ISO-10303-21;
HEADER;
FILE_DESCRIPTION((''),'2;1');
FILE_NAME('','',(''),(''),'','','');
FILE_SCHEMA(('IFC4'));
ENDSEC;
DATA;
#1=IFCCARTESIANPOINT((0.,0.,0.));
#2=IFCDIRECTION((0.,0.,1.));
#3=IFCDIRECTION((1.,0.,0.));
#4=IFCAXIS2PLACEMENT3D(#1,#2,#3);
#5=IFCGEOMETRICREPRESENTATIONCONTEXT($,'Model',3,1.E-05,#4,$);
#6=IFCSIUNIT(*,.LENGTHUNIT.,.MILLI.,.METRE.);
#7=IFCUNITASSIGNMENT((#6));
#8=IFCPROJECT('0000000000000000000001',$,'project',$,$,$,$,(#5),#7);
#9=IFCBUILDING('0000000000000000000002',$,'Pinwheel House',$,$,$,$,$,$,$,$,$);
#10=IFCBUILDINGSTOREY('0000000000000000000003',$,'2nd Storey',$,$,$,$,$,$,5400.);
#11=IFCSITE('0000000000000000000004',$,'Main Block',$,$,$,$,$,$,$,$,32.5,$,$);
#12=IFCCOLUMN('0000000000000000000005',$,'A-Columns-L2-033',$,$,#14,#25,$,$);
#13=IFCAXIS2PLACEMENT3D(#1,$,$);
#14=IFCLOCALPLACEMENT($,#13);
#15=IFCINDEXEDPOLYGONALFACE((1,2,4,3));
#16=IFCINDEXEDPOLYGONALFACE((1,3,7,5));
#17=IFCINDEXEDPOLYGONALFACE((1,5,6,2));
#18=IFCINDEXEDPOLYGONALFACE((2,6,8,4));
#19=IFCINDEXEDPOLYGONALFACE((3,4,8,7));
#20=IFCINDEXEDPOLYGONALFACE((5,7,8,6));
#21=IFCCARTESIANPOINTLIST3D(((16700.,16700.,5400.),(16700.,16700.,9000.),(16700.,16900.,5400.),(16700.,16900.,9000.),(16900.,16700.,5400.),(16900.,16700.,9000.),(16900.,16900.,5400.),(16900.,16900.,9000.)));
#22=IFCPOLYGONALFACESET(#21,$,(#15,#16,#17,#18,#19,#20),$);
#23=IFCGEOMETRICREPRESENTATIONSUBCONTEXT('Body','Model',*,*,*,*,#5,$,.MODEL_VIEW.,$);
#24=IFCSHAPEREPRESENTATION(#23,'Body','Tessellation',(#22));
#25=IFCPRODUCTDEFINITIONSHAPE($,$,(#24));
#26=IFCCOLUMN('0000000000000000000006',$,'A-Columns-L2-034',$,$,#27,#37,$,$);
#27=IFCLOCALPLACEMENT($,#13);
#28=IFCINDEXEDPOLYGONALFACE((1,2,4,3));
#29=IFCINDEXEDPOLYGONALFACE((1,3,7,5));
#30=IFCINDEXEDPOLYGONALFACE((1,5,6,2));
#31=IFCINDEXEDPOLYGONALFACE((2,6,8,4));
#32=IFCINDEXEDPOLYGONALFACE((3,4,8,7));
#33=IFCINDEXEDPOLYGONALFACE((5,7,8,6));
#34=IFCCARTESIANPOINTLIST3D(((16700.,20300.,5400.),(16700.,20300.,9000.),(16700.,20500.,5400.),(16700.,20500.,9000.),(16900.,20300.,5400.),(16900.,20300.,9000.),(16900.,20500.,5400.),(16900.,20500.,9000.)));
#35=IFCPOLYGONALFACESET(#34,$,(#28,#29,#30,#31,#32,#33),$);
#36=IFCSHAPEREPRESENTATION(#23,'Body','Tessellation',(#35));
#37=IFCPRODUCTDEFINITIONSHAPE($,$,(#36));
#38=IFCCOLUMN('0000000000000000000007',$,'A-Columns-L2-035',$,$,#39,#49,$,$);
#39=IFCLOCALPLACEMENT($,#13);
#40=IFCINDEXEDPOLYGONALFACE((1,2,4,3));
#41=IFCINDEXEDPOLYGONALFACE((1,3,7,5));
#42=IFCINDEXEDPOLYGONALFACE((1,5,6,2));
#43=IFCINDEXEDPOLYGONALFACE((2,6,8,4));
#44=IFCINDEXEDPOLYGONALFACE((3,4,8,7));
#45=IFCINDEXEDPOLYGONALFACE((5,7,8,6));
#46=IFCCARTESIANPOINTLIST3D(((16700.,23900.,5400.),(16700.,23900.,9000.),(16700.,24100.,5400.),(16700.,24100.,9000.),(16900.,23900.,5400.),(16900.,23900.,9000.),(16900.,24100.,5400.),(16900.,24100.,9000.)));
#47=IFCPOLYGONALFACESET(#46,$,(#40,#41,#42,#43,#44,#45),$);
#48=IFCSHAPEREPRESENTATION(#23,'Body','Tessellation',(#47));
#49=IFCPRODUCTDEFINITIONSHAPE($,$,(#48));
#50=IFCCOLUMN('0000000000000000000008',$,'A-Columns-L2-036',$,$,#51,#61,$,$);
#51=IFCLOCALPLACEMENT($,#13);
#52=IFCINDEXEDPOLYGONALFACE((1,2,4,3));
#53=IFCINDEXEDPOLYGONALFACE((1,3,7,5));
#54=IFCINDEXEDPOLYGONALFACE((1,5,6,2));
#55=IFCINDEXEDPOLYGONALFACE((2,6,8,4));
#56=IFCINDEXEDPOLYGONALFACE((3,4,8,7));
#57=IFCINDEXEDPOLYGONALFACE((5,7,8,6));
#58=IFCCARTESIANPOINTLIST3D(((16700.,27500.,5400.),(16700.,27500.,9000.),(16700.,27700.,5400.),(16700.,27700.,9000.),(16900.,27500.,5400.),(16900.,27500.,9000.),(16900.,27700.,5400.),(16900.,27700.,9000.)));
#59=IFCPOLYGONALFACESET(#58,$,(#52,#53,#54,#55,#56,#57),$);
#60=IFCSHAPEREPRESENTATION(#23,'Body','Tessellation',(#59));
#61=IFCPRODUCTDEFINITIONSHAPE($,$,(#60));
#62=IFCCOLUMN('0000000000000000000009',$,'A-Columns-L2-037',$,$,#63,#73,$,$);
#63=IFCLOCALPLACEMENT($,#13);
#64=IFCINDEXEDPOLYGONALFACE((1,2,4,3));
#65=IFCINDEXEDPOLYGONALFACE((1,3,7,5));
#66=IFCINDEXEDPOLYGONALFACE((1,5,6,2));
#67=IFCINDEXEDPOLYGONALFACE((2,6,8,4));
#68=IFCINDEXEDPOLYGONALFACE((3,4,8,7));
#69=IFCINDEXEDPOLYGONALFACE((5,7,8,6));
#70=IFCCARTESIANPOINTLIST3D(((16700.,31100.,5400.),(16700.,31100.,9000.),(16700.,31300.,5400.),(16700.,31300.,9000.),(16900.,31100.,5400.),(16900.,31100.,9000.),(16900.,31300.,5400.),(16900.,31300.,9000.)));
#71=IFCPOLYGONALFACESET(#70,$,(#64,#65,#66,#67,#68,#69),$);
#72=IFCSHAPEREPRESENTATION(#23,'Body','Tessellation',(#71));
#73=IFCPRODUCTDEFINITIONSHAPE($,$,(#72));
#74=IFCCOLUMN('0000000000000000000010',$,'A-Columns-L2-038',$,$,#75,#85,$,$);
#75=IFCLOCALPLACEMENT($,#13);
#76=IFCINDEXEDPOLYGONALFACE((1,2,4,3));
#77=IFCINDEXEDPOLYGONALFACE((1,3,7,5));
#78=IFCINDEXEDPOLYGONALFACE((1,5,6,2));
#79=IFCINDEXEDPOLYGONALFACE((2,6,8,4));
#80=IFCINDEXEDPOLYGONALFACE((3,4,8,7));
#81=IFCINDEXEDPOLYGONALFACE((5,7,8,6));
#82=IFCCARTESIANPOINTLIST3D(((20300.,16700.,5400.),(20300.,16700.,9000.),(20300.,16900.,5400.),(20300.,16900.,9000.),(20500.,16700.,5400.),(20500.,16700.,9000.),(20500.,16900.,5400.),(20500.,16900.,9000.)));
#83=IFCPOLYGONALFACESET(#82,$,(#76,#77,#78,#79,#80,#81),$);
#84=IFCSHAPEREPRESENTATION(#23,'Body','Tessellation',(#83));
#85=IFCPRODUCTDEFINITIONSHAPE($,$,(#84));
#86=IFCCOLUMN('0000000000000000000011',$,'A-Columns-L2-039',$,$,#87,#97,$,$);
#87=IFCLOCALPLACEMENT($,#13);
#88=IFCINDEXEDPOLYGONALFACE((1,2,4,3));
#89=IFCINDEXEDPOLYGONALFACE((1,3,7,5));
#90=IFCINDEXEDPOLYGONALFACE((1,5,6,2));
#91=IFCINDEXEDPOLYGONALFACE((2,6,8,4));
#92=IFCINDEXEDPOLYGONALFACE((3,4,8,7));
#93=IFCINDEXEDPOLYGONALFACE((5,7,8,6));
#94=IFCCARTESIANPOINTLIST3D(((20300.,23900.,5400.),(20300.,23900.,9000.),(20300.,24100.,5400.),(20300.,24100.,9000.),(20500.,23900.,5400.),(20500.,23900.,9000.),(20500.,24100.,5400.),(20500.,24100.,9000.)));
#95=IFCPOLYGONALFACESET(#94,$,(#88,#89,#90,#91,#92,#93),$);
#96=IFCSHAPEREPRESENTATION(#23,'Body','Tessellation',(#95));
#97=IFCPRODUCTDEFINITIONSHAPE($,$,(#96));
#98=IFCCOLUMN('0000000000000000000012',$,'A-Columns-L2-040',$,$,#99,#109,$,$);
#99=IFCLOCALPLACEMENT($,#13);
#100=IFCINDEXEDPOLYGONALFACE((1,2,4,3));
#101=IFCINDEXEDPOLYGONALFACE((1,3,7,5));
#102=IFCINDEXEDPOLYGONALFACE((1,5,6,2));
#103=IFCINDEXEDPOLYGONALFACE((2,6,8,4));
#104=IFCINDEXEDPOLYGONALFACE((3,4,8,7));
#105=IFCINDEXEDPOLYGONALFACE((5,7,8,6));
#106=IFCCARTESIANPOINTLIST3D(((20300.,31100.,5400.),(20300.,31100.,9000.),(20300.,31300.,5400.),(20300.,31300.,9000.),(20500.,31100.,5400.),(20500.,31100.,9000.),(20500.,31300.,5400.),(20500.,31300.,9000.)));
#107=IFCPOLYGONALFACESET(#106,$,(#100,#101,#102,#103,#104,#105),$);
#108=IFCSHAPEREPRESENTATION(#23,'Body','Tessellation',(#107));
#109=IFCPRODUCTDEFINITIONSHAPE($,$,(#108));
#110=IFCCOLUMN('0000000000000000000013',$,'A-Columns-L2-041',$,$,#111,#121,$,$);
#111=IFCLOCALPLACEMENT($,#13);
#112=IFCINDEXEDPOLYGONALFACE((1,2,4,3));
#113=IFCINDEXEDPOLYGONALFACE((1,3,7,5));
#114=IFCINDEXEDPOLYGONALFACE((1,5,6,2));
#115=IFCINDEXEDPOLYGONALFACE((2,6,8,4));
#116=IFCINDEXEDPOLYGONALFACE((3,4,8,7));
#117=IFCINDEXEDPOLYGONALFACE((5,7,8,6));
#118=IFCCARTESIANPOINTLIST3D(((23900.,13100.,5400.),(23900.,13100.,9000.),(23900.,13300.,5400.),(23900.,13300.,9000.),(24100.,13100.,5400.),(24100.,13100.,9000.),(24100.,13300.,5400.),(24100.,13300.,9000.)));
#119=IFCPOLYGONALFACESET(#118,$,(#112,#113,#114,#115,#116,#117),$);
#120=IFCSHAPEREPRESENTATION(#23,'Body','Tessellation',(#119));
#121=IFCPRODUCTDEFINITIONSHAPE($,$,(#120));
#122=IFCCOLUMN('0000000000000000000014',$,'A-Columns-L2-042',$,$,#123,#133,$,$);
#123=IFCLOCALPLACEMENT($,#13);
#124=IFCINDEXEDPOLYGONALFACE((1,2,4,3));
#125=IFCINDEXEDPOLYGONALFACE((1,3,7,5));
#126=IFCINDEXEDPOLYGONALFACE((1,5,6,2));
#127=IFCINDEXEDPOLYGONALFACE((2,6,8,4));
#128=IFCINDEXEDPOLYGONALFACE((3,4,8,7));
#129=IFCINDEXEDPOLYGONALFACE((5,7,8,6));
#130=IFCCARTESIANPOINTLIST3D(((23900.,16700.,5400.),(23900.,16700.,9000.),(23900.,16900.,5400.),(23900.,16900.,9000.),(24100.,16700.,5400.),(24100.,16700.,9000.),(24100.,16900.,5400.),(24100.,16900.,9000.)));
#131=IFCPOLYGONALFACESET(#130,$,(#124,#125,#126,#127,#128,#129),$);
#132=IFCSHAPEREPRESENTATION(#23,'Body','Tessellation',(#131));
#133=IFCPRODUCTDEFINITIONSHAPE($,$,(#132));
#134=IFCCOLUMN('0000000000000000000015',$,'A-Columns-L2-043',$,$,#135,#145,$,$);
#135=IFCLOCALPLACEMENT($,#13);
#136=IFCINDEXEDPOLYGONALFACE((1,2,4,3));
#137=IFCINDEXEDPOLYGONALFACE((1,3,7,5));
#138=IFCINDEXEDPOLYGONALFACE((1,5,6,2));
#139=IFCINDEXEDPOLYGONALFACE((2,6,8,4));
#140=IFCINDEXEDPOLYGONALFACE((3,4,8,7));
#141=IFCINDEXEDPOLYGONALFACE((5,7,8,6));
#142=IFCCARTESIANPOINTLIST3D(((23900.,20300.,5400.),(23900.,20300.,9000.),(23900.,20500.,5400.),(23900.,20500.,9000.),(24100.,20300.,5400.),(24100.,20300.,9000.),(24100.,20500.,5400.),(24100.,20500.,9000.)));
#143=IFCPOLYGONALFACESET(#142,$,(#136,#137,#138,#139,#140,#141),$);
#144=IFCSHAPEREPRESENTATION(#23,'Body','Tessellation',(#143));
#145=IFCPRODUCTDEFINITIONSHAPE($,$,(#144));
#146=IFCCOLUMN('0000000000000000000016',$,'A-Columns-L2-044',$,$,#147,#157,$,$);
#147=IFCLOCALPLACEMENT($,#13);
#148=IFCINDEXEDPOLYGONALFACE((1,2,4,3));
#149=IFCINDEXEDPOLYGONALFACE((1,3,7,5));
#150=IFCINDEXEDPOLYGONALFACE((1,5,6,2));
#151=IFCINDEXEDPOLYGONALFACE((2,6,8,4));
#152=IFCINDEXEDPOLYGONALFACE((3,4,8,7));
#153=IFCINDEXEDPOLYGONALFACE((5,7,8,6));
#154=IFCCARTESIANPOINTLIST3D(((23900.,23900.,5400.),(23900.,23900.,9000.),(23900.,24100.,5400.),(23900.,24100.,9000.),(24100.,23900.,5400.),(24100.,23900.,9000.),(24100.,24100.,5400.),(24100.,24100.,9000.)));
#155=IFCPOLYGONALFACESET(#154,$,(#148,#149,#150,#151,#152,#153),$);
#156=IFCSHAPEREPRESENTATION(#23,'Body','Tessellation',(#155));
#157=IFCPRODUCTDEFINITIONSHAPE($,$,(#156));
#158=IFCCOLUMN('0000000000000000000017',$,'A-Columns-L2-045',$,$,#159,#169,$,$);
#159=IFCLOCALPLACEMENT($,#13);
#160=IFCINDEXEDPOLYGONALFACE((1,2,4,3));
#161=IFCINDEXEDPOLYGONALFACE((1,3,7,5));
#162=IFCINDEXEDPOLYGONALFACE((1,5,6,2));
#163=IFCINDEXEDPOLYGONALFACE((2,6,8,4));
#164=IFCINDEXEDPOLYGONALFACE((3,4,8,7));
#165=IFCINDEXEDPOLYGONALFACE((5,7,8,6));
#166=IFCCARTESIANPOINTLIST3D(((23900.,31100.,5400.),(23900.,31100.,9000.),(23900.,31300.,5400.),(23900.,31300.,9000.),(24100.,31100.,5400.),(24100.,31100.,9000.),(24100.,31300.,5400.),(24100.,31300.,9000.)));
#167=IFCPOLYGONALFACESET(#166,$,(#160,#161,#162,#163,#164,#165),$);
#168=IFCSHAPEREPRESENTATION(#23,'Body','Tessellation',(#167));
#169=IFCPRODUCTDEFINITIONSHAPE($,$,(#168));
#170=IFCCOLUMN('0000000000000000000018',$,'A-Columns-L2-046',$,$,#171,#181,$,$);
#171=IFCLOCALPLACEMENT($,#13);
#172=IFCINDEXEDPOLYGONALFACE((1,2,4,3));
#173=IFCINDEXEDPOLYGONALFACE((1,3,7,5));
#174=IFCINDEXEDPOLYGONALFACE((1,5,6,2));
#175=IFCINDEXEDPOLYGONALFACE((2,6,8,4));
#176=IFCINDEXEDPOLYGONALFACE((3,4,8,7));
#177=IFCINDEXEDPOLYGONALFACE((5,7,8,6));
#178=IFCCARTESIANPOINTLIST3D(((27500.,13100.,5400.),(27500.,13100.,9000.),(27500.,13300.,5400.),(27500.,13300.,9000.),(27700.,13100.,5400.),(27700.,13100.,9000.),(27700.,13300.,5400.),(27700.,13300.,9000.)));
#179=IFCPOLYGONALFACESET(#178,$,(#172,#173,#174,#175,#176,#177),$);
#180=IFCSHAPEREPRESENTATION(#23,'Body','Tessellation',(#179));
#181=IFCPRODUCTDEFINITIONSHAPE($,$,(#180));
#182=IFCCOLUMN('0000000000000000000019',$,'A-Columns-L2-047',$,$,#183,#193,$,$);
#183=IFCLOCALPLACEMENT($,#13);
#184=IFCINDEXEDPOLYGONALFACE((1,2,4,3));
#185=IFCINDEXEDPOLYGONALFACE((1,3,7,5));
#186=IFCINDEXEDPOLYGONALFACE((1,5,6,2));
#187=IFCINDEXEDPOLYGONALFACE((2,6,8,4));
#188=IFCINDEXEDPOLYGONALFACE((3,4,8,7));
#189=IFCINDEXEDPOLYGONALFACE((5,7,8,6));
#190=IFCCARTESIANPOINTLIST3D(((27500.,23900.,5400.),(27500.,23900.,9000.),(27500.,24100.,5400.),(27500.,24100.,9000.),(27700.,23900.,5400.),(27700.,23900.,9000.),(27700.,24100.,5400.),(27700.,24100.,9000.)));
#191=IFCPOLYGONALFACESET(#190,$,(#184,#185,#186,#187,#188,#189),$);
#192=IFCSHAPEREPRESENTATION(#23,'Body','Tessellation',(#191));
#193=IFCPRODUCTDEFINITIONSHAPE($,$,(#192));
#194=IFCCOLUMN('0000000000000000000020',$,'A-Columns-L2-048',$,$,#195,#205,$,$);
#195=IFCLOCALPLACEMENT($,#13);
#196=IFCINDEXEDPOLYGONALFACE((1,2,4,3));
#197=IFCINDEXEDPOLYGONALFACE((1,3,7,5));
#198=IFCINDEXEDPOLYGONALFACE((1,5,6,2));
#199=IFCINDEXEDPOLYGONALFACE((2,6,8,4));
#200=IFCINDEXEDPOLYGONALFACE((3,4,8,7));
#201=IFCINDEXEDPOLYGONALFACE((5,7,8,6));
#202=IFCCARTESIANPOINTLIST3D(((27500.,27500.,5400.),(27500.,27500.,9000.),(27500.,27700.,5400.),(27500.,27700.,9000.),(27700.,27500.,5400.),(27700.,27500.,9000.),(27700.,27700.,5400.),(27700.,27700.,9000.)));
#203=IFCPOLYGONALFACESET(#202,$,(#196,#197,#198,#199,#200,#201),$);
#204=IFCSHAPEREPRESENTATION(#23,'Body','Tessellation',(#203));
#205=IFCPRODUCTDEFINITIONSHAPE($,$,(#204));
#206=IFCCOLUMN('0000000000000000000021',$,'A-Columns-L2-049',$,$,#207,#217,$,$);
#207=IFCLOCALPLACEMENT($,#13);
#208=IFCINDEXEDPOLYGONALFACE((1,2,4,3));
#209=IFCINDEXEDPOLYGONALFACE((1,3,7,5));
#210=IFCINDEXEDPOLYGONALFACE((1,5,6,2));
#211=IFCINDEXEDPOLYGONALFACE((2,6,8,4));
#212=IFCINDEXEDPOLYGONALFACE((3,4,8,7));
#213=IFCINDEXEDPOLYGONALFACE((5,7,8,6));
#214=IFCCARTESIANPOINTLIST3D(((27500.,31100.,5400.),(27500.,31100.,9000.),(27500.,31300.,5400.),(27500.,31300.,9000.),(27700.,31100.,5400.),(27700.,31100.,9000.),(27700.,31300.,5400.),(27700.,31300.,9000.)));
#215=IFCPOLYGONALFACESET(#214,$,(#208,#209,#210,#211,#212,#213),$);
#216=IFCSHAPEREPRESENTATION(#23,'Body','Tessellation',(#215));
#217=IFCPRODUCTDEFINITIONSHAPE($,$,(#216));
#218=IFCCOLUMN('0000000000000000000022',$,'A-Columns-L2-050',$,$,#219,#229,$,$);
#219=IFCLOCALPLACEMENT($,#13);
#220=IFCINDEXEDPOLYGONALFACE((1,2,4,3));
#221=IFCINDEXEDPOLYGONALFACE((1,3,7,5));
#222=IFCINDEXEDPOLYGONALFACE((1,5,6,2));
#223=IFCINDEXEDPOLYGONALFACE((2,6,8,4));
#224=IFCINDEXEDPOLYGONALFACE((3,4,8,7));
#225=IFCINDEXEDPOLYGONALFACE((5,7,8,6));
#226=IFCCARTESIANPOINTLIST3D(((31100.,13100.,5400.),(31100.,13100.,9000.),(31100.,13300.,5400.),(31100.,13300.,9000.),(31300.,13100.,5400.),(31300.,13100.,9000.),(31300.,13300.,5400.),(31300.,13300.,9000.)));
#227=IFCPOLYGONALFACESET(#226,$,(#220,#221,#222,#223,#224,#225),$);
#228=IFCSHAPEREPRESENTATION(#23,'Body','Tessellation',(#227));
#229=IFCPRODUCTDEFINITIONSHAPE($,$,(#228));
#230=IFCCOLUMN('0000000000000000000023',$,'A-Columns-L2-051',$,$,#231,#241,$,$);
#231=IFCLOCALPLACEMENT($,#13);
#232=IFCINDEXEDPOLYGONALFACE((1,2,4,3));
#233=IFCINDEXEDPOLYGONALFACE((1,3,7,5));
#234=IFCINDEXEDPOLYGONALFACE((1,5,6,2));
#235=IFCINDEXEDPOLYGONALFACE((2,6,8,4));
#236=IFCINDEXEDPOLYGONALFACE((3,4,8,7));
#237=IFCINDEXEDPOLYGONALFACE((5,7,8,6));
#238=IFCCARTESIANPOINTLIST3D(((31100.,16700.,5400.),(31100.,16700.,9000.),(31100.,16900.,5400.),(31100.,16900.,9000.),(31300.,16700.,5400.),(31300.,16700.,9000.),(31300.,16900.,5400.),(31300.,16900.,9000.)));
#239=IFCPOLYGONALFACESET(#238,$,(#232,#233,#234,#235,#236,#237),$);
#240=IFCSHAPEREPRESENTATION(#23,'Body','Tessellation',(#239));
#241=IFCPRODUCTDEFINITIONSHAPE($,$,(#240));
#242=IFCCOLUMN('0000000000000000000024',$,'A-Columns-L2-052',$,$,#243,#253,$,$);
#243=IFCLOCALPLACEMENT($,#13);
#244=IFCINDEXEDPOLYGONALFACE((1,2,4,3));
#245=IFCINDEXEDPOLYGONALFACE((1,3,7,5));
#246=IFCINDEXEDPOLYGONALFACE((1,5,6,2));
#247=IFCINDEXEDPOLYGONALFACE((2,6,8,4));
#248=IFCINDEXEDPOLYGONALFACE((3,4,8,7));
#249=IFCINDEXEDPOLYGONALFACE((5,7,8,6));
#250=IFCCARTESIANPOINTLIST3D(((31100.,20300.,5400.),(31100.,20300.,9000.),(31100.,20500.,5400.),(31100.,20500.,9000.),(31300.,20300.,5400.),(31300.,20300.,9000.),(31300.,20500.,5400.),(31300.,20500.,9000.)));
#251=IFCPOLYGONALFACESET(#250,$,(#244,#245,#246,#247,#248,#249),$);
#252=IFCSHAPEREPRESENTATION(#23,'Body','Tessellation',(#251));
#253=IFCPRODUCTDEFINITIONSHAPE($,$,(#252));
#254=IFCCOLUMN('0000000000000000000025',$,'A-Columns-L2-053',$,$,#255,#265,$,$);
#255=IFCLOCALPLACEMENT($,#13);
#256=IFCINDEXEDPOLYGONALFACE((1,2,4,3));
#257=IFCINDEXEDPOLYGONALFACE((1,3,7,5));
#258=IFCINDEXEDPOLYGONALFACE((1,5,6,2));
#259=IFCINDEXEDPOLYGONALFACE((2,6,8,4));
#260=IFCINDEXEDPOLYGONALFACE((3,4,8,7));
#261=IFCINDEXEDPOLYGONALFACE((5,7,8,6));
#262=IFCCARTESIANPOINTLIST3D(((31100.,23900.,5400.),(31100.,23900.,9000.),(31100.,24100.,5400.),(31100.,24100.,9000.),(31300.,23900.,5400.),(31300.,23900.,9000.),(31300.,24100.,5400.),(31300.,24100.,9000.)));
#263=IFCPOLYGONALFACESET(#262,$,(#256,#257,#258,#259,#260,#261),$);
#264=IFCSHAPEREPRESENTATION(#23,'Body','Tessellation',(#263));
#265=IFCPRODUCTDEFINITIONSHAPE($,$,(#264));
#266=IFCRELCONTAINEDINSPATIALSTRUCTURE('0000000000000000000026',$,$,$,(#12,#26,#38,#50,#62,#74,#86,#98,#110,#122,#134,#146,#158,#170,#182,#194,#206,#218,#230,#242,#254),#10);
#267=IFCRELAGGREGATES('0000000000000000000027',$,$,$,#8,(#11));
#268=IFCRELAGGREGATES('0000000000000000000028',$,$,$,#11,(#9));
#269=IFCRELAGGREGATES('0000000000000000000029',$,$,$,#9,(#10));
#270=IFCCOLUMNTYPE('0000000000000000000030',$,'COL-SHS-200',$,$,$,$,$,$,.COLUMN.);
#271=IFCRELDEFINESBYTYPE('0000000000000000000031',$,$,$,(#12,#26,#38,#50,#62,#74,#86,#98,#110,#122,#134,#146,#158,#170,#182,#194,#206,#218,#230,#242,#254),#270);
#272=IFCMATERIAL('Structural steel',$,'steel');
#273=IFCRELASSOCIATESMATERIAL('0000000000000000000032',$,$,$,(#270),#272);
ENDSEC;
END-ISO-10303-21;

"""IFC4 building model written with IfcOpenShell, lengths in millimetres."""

from ifc_helpers import new_model, si_unit, frame, origin_with_axes, place, context, subcontext, project, spatial, indexed_curve, outline, extrude, material, type_object, element, save


model = new_model("IFC4")

# Units and contexts
model_context = context("Model", 3, precision=1e-05, world=origin_with_axes())
body_context = subcontext(model_context, "Body", "Model", "MODEL_VIEW")
ifc_project = project(units=[si_unit("LENGTHUNIT", "METRE", prefix="MILLI")], contexts=[model_context])

# Site, building, storey
site = spatial("IfcSite", under=ifc_project, Name="Main Block", RefElevation=32.5)
building = spatial("IfcBuilding", under=site, Name="Pinwheel House")
storey = spatial("IfcBuildingStorey", under=building, Name="2nd Storey", Elevation=5400.0)

# Columns
ifc_material_1 = material(Name="Structural steel", Category="steel")
column_type = type_object("IfcColumnType", Name="COL-SHS-200", PredefinedType="COLUMN", material=ifc_material_1)
for number, where, z_axis, x_axis, name in (
    (1, (16800.0, 16800.0, 5400.0), (0.0, 0.0, 1.0), (1.0, 0.0, 0.0), "A-Columns-L2-033"),
    (2, (16800.0, 20400.0, 5400.0), (0.0, 0.0, 1.0), (1.0, 0.0, 0.0), "A-Columns-L2-034"),
    (3, (16800.0, 24000.0, 5400.0), (0.0, 0.0, 1.0), (1.0, 0.0, 0.0), "A-Columns-L2-035"),
    (4, (16800.0, 27600.0, 5400.0), (0.0, 0.0, 1.0), (1.0, 0.0, 0.0), "A-Columns-L2-036"),
    (5, (16800.0, 31200.0, 5400.0), (0.0, 0.0, 1.0), (1.0, 0.0, 0.0), "A-Columns-L2-037"),
    (6, (20400.0, 16800.0, 5400.0), (0.0, 0.0, 1.0), (1.0, 0.0, 0.0), "A-Columns-L2-038"),
    (7, (20400.0, 24000.0, 5400.0), (0.0, 0.0, 1.0), (1.0, 0.0, 0.0), "A-Columns-L2-039"),
    (8, (20400.0, 31200.0, 5400.0), (0.0, 0.0, 1.0), (1.0, 0.0, 0.0), "A-Columns-L2-040"),
    (9, (24000.0, 13200.0, 5400.0), (0.0, 0.0, 1.0), (1.0, 0.0, 0.0), "A-Columns-L2-041"),
    (10, (24000.0, 16800.0, 5400.0), (0.0, 0.0, 1.0), (1.0, 0.0, 0.0), "A-Columns-L2-042"),
    (11, (24000.0, 20400.0, 5400.0), (0.0, 0.0, 1.0), (1.0, 0.0, 0.0), "A-Columns-L2-043"),
    (12, (24000.0, 24000.0, 5400.0), (0.0, 0.0, 1.0), (1.0, 0.0, 0.0), "A-Columns-L2-044"),
    (13, (24000.0, 31200.0, 5400.0), (0.0, 0.0, 1.0), (1.0, 0.0, 0.0), "A-Columns-L2-045"),
    (14, (27600.0, 13200.0, 5400.0), (0.0, 0.0, 1.0), (1.0, 0.0, 0.0), "A-Columns-L2-046"),
    (15, (27600.0, 24000.0, 5400.0), (0.0, 0.0, 1.0), (1.0, 0.0, 0.0), "A-Columns-L2-047"),
    (16, (27600.0, 27600.0, 5400.0), (0.0, 0.0, 1.0), (1.0, 0.0, 0.0), "A-Columns-L2-048"),
    (17, (27600.0, 31200.0, 5400.0), (0.0, 0.0, 1.0), (1.0, 0.0, 0.0), "A-Columns-L2-049"),
    (18, (31200.0, 13200.0, 5400.0), (0.0, 0.0, 1.0), (1.0, 0.0, 0.0), "A-Columns-L2-050"),
    (19, (31200.0, 16800.0, 5400.0), (0.0, 0.0, 1.0), (1.0, 0.0, 0.0), "A-Columns-L2-051"),
    (20, (31200.0, 20400.0, 5400.0), (0.0, 0.0, 1.0), (1.0, 0.0, 0.0), "A-Columns-L2-052"),
    (21, (31200.0, 24000.0, 5400.0), (0.0, 0.0, 1.0), (1.0, 0.0, 0.0), "A-Columns-L2-053"),
):
    element("IfcColumn", number, at=place(None, frame(where, z_axis=z_axis, x_axis=x_axis)), inside=storey, type_object=column_type, Name=name, context=body_context, shape_type="SweptSolid", body=[
        extrude(outline(indexed_curve([(-100.0, -100.0), (100.0, -100.0), (100.0, 100.0), (-100.0, 100.0)])), None, (0.0, 0.0, 1.0), 3600.0),
    ])

save(model, "model.ifc")
